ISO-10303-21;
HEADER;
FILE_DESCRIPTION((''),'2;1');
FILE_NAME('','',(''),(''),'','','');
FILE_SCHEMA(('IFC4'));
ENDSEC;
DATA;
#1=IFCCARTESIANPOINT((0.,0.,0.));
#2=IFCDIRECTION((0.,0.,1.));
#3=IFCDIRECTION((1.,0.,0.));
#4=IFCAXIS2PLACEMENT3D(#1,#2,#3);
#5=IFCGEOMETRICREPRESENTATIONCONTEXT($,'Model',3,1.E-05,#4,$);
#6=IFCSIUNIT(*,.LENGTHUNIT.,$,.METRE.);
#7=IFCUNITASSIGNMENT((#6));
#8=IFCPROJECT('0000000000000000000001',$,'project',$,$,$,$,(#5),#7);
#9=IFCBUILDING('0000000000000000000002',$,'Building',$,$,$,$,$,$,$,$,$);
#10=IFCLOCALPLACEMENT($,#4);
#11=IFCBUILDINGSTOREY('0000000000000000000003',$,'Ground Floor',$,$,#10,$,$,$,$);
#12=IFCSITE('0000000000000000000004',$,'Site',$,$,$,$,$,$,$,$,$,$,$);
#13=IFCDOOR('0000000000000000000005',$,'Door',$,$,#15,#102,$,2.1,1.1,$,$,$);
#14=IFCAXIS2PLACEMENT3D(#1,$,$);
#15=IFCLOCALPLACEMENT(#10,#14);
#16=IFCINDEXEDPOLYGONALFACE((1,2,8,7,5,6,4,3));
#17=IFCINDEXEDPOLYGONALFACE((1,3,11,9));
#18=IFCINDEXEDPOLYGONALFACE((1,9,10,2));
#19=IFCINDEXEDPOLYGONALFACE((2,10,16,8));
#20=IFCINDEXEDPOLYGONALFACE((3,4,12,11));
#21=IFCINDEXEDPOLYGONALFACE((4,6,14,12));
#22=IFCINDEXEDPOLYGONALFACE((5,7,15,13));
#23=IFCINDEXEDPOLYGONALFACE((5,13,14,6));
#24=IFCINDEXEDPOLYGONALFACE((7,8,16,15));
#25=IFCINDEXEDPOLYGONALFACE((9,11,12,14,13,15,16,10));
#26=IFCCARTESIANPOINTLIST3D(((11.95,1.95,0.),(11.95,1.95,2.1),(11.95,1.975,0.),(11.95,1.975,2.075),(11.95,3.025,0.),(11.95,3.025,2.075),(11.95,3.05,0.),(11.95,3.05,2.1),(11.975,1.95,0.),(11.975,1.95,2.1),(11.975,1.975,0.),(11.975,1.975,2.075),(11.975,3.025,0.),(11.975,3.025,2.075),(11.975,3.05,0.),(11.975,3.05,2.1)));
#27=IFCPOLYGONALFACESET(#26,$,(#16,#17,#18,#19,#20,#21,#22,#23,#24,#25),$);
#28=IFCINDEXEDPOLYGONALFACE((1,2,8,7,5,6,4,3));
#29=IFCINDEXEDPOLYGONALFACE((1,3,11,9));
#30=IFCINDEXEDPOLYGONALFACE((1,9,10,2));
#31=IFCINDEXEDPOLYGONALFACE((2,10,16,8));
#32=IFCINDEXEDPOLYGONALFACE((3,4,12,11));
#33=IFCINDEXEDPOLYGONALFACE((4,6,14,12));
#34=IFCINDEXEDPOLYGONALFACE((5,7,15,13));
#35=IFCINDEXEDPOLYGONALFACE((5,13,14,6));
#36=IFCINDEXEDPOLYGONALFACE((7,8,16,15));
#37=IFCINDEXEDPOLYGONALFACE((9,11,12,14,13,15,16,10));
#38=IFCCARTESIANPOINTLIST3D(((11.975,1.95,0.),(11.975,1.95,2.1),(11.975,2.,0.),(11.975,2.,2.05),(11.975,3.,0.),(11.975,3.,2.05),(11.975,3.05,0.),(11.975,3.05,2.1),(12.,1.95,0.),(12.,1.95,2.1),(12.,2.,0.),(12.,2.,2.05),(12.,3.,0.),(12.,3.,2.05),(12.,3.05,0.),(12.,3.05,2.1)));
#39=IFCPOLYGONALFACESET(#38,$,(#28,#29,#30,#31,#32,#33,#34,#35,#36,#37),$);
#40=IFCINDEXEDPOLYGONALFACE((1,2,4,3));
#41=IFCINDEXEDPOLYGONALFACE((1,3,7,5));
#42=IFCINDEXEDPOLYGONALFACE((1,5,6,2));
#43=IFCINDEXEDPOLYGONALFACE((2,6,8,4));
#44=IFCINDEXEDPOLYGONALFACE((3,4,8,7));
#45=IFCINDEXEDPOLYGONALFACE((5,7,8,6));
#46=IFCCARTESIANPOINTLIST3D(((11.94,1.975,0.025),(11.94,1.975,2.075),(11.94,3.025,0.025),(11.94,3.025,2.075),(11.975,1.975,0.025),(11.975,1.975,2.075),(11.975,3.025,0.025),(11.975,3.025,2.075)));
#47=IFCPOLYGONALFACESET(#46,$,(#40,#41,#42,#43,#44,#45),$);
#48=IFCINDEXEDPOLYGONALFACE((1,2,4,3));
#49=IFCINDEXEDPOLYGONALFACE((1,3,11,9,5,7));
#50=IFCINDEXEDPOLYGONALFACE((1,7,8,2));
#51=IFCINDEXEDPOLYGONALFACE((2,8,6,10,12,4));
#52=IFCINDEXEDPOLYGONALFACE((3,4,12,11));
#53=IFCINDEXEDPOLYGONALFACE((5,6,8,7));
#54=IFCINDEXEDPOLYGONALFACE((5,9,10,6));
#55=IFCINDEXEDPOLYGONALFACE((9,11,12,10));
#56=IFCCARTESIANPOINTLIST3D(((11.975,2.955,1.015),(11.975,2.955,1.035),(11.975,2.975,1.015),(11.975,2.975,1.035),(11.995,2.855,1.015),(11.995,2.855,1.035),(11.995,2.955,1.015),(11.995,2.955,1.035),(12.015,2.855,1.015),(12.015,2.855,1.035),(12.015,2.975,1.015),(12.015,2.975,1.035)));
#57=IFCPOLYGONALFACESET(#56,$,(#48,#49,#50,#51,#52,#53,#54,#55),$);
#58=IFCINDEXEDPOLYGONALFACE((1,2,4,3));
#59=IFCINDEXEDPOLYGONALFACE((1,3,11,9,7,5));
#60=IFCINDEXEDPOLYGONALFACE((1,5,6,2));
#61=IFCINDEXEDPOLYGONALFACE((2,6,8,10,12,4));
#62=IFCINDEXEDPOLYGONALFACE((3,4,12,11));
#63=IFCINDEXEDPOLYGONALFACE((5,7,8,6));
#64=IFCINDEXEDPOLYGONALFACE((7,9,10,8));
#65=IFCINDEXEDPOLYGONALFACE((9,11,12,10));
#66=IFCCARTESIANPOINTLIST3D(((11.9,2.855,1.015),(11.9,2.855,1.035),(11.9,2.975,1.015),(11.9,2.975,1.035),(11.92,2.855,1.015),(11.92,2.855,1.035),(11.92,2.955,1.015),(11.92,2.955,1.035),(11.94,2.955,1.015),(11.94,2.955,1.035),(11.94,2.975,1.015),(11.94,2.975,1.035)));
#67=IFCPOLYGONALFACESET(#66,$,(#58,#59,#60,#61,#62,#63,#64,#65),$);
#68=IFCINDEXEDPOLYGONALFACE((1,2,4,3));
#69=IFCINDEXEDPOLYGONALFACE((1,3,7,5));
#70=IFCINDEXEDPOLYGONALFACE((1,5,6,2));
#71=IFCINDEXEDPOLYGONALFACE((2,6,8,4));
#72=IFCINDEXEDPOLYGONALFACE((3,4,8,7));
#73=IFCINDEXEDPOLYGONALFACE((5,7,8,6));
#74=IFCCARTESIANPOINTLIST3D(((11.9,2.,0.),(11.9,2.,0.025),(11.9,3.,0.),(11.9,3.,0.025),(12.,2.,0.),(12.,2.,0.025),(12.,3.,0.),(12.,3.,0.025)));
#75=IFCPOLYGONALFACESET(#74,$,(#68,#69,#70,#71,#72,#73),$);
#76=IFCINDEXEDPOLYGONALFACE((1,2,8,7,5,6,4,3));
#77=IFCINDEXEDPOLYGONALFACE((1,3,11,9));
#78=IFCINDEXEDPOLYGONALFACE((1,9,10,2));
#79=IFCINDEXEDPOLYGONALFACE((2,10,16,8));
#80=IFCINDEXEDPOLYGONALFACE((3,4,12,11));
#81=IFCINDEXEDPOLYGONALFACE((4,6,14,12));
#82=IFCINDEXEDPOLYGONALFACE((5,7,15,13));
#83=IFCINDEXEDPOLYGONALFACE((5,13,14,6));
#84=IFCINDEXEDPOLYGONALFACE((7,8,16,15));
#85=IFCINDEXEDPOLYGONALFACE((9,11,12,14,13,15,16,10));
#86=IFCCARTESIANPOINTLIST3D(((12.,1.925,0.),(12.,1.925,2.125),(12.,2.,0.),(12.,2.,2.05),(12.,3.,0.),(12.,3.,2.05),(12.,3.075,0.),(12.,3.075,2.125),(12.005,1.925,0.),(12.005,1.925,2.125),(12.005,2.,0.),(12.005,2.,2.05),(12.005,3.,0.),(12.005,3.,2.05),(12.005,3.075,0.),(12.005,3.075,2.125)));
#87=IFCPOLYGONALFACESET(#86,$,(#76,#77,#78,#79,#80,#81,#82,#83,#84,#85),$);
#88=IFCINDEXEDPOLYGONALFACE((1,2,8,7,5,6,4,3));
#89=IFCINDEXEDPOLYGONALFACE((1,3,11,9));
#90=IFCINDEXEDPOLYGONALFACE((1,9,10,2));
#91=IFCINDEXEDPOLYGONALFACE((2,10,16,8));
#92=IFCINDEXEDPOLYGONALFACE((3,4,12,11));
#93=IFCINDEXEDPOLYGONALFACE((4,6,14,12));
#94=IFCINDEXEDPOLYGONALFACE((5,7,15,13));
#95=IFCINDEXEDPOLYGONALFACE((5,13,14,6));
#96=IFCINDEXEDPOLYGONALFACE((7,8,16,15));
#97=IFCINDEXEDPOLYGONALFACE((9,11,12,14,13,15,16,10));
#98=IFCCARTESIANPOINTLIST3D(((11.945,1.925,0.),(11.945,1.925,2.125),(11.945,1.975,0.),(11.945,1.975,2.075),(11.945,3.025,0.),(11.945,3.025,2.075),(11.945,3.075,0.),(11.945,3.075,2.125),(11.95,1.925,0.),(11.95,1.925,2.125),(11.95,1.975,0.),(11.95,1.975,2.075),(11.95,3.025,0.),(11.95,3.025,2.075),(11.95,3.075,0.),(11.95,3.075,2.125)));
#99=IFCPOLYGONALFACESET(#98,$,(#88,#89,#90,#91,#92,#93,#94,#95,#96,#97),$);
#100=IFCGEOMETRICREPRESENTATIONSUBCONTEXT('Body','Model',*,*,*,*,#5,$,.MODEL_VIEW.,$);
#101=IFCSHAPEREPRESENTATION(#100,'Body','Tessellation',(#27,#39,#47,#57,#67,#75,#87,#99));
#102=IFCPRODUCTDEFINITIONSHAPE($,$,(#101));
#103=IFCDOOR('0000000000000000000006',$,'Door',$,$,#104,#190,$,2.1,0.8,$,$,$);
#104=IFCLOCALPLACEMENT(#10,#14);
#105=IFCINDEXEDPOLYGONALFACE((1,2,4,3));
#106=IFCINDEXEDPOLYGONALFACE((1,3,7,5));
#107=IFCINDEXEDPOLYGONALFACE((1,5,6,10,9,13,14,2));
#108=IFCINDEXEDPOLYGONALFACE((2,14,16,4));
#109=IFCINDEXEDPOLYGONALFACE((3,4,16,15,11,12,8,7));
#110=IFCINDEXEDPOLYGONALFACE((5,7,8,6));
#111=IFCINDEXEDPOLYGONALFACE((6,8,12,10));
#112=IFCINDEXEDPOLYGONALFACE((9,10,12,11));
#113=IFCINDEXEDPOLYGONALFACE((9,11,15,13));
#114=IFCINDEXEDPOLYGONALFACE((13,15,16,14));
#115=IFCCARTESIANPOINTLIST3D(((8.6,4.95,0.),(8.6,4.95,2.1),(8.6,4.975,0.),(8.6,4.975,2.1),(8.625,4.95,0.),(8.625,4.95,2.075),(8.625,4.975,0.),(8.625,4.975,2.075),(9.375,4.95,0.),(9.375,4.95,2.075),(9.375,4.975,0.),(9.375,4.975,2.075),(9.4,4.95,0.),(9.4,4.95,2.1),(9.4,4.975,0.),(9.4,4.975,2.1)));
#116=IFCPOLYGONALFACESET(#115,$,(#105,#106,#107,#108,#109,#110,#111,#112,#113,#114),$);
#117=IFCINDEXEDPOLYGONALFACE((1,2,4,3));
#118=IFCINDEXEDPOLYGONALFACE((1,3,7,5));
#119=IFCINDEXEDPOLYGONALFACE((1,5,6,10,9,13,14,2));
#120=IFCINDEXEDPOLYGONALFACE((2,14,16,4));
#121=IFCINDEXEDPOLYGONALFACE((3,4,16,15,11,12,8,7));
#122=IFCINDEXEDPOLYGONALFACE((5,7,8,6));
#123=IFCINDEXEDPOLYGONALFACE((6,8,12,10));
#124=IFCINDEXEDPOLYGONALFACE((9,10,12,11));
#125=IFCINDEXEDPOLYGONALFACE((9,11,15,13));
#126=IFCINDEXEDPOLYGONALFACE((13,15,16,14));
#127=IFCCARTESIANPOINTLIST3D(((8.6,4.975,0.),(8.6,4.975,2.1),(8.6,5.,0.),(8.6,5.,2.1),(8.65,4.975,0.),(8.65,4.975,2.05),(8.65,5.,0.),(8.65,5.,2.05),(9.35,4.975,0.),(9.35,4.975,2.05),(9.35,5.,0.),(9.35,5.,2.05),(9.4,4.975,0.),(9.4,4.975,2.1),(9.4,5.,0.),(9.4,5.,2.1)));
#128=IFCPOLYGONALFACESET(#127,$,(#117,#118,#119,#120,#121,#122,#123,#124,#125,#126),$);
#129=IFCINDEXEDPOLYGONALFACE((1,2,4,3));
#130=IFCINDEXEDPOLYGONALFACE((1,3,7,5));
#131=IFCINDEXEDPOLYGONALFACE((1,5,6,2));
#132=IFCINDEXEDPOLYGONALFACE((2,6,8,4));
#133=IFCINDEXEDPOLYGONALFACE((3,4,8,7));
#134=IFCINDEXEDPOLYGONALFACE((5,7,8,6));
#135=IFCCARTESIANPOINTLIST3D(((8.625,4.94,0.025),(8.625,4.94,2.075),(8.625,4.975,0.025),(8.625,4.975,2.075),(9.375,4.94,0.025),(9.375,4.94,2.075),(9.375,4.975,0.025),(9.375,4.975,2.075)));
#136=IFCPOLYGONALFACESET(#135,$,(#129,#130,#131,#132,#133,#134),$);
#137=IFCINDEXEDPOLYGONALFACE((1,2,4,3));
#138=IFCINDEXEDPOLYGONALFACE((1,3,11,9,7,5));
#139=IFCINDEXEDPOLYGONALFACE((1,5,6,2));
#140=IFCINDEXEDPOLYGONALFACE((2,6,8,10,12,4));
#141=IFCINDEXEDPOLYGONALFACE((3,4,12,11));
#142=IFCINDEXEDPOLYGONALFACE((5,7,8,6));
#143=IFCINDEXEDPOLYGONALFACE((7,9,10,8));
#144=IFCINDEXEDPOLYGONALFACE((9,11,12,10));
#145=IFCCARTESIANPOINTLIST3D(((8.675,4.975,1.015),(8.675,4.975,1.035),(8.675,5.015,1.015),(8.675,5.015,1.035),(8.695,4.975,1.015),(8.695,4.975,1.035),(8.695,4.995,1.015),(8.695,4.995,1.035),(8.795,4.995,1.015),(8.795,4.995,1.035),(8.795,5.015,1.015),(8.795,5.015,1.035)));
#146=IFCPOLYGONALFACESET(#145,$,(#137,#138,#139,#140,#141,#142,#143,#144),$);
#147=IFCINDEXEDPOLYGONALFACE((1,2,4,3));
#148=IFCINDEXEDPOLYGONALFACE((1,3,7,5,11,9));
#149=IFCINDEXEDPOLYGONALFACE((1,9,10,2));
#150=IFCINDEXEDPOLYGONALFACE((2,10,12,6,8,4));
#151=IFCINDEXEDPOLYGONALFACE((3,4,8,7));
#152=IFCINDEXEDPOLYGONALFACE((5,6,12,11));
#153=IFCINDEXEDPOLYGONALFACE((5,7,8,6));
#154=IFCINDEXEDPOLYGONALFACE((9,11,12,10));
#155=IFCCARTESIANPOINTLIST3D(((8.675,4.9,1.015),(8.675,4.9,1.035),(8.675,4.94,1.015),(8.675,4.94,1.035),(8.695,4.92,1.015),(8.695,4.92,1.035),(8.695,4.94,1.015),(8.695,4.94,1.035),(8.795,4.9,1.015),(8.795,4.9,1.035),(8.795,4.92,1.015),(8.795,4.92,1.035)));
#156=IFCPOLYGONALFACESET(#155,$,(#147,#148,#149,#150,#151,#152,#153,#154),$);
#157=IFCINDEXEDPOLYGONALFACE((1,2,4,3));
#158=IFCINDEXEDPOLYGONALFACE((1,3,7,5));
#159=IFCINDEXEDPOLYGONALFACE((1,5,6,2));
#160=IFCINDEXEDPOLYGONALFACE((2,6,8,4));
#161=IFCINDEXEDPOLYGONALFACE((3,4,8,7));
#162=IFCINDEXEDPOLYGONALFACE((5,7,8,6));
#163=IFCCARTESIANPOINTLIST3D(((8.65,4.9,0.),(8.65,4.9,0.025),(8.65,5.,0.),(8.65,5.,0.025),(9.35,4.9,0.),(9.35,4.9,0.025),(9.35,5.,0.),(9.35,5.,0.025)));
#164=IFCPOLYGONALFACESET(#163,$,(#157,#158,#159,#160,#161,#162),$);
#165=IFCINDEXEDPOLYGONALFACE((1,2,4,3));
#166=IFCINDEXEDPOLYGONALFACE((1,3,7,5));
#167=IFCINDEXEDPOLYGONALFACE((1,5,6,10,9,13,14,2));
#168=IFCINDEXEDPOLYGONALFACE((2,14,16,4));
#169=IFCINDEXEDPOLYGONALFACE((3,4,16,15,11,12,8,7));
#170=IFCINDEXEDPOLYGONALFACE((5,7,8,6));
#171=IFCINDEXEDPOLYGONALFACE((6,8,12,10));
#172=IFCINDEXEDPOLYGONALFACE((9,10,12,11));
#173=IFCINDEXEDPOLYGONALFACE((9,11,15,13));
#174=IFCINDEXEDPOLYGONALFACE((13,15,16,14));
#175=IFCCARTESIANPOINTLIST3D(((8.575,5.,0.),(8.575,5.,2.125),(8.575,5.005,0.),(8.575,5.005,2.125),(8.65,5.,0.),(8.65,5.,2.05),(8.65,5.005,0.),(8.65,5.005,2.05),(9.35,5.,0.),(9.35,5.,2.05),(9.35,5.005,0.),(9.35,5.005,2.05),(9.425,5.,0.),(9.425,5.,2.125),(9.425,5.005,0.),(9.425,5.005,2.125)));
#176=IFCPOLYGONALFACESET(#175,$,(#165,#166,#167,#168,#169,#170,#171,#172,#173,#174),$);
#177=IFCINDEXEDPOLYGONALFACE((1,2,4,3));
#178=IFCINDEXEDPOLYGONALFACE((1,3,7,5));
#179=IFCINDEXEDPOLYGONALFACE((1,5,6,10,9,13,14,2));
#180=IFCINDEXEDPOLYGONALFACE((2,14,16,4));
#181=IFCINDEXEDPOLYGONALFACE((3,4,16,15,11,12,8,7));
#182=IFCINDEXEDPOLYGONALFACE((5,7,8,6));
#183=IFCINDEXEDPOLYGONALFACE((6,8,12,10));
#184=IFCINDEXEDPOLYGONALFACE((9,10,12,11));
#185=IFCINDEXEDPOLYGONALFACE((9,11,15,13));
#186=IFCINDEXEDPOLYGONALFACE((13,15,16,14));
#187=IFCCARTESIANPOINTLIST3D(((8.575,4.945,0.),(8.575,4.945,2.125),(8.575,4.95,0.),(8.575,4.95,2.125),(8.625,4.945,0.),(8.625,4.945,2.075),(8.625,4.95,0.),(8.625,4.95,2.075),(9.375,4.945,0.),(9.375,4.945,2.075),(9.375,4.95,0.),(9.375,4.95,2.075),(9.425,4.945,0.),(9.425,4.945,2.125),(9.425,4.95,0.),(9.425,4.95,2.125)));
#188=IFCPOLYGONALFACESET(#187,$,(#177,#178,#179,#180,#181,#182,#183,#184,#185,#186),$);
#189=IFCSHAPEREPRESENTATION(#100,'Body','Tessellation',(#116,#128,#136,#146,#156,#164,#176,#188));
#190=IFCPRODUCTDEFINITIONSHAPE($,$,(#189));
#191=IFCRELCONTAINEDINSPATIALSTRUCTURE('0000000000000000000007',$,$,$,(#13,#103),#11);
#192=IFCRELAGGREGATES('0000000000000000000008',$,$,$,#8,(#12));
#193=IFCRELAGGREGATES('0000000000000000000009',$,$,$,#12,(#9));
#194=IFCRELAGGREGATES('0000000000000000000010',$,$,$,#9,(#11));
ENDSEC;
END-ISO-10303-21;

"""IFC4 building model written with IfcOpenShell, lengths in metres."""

from ifc_helpers import new_model, si_unit, frame, origin_with_axes, place, context, subcontext, project, spatial, line, indexed_curve, outline, extrude, element, save


model = new_model("IFC4")

# Units and contexts
model_context = context("Model", 3, precision=1e-05, world=origin_with_axes())
body_context = subcontext(model_context, "Body", "Model", "MODEL_VIEW")
ifc_project = project(units=[si_unit("LENGTHUNIT", "METRE")], contexts=[model_context])

# Site, building, storey
site = spatial("IfcSite", under=ifc_project, Name="Site")
building = spatial("IfcBuilding", under=site, Name="Building")
storey_placement = place(None, origin_with_axes())
storey = spatial("IfcBuildingStorey", under=building, at=storey_placement, Name="Ground Floor")

# Doors
door_1_placement = place(storey_placement, frame((12.0, 1.95, 0.0), z_axis=(0.0, 0.0, 1.0), x_axis=(0.0, 1.0, 0.0)))
element("IfcDoor", 1, at=door_1_placement, inside=storey, Name="Door", OverallHeight=2.1, OverallWidth=1.1, context=body_context, shape_type="SweptSolid", body=[
    extrude(outline(indexed_curve([(0.0, 0.0), (0.0, 2.1), (1.1, 2.1), (1.1, 0.0), (1.075, 0.0), (1.075, 2.075), (0.025, 2.075), (0.025, 0.0)], segments=[line(1, 2, 3, 4, 5, 6, 7, 8, 1)])), frame((0.0, 0.025, 0.0), z_axis=(0.0, -1.0, 0.0), x_axis=(1.0, 0.0, 0.0)), (0.0, 0.0, -1.0), 0.025),
    extrude(outline(indexed_curve([(0.0, 0.0), (0.0, 2.1), (1.1, 2.1), (1.1, 0.0), (1.05, 0.0), (1.05, 2.05), (0.05, 2.05), (0.05, 0.0)], segments=[line(1, 2, 3, 4, 5, 6, 7, 8, 1)])), frame((0.0, 0.0, 0.0), z_axis=(0.0, -1.0, 0.0), x_axis=(1.0, 0.0, 0.0)), (0.0, 0.0, -1.0), 0.025),
    extrude(outline(indexed_curve([(0.0, 0.0), (1.05, 0.0), (1.05, 0.035), (0.0, 0.035)], segments=[line(1, 2, 3, 4, 1)])), frame((0.025, 0.025, 0.025), z_axis=(0.0, 0.0, 1.0), x_axis=(1.0, 0.0, 0.0)), (0.0, 0.0, 1.0), 2.05),
    extrude(outline(indexed_curve([(0.0, 0.0), (0.0, -0.04), (-0.12, -0.04), (-0.12, -0.02), (-0.02, -0.02), (-0.02, 0.0)], segments=[line(1, 2, 3, 4, 5, 6, 1)])), frame((1.025, 0.025, 1.015), z_axis=(0.0, 0.0, 1.0), x_axis=(1.0, 0.0, 0.0)), (0.0, 0.0, 1.0), 0.02),
    extrude(outline(indexed_curve([(0.0, 0.0), (0.0, 0.04), (-0.12, 0.04), (-0.12, 0.02), (-0.02, 0.02), (-0.02, 0.0)], segments=[line(1, 2, 3, 4, 5, 6, 1)])), frame((1.025, 0.06, 1.015), z_axis=(0.0, 0.0, 1.0), x_axis=(1.0, 0.0, 0.0)), (0.0, 0.0, 1.0), 0.02),
    extrude(outline(indexed_curve([(0.0, 0.0), (1.0, 0.0), (1.0, 0.1), (0.0, 0.1)], segments=[line(1, 2, 3, 4, 1)])), frame((0.05, 0.0, 0.0), z_axis=(0.0, 0.0, 1.0), x_axis=(1.0, 0.0, 0.0)), (0.0, 0.0, 1.0), 0.025),
    extrude(outline(indexed_curve([(0.0, 0.0), (0.0, 2.125), (1.15, 2.125), (1.15, 0.0), (1.075, 0.0), (1.075, 2.05), (0.075, 2.05), (0.075, 0.0)], segments=[line(1, 2, 3, 4, 5, 6, 7, 8, 1)])), frame((-0.025, -0.005, 0.0), z_axis=(0.0, -1.0, 0.0), x_axis=(1.0, 0.0, 0.0)), (0.0, 0.0, -1.0), 0.005),
    extrude(outline(indexed_curve([(0.0, 0.0), (0.0, 2.125), (1.15, 2.125), (1.15, 0.0), (1.1, 0.0), (1.1, 2.075), (0.05, 2.075), (0.05, 0.0)], segments=[line(1, 2, 3, 4, 5, 6, 7, 8, 1)])), frame((-0.025, 0.05, 0.0), z_axis=(0.0, -1.0, 0.0), x_axis=(1.0, 0.0, 0.0)), (0.0, 0.0, -1.0), 0.005),
])
door_2_placement = place(storey_placement, frame((9.4, 5.0, 0.0), z_axis=(0.0, 0.0, 1.0), x_axis=(-1.0, 0.0, 0.0)))
element("IfcDoor", 2, at=door_2_placement, inside=storey, Name="Door", OverallHeight=2.1, OverallWidth=0.8, context=body_context, shape_type="SweptSolid", body=[
    extrude(outline(indexed_curve([(0.0, 0.0), (0.0, 2.1), (0.8, 2.1), (0.8, 0.0), (0.775, 0.0), (0.775, 2.075), (0.025, 2.075), (0.025, 0.0)], segments=[line(1, 2, 3, 4, 5, 6, 7, 8, 1)])), frame((0.0, 0.025, 0.0), z_axis=(0.0, -1.0, 0.0), x_axis=(1.0, 0.0, 0.0)), (0.0, 0.0, -1.0), 0.025),
    extrude(outline(indexed_curve([(0.0, 0.0), (0.0, 2.1), (0.8, 2.1), (0.8, 0.0), (0.75, 0.0), (0.75, 2.05), (0.05, 2.05), (0.05, 0.0)], segments=[line(1, 2, 3, 4, 5, 6, 7, 8, 1)])), frame((0.0, 0.0, 0.0), z_axis=(0.0, -1.0, 0.0), x_axis=(1.0, 0.0, 0.0)), (0.0, 0.0, -1.0), 0.025),
    extrude(outline(indexed_curve([(0.0, 0.0), (0.75, 0.0), (0.75, 0.035), (0.0, 0.035)], segments=[line(1, 2, 3, 4, 1)])), frame((0.025, 0.025, 0.025), z_axis=(0.0, 0.0, 1.0), x_axis=(1.0, 0.0, 0.0)), (0.0, 0.0, 1.0), 2.05),
    extrude(outline(indexed_curve([(0.0, 0.0), (0.0, -0.04), (-0.12, -0.04), (-0.12, -0.02), (-0.02, -0.02), (-0.02, 0.0)], segments=[line(1, 2, 3, 4, 5, 6, 1)])), frame((0.725, 0.025, 1.015), z_axis=(0.0, 0.0, 1.0), x_axis=(1.0, 0.0, 0.0)), (0.0, 0.0, 1.0), 0.02),
    extrude(outline(indexed_curve([(0.0, 0.0), (0.0, 0.04), (-0.12, 0.04), (-0.12, 0.02), (-0.02, 0.02), (-0.02, 0.0)], segments=[line(1, 2, 3, 4, 5, 6, 1)])), frame((0.725, 0.06, 1.015), z_axis=(0.0, 0.0, 1.0), x_axis=(1.0, 0.0, 0.0)), (0.0, 0.0, 1.0), 0.02),
    extrude(outline(indexed_curve([(0.0, 0.0), (0.7, 0.0), (0.7, 0.1), (0.0, 0.1)], segments=[line(1, 2, 3, 4, 1)])), frame((0.05, 0.0, 0.0), z_axis=(0.0, 0.0, 1.0), x_axis=(1.0, 0.0, 0.0)), (0.0, 0.0, 1.0), 0.025),
    extrude(outline(indexed_curve([(0.0, 0.0), (0.0, 2.125), (0.85, 2.125), (0.85, 0.0), (0.775, 0.0), (0.775, 2.05), (0.075, 2.05), (0.075, 0.0)], segments=[line(1, 2, 3, 4, 5, 6, 7, 8, 1)])), frame((-0.025, -0.005, 0.0), z_axis=(0.0, -1.0, 0.0), x_axis=(1.0, 0.0, 0.0)), (0.0, 0.0, -1.0), 0.005),
    extrude(outline(indexed_curve([(0.0, 0.0), (0.0, 2.125), (0.85, 2.125), (0.85, 0.0), (0.8, 0.0), (0.8, 2.075), (0.05, 2.075), (0.05, 0.0)], segments=[line(1, 2, 3, 4, 5, 6, 7, 8, 1)])), frame((-0.025, 0.05, 0.0), z_axis=(0.0, -1.0, 0.0), x_axis=(1.0, 0.0, 0.0)), (0.0, 0.0, -1.0), 0.005),
])

save(model, "model.ifc")
